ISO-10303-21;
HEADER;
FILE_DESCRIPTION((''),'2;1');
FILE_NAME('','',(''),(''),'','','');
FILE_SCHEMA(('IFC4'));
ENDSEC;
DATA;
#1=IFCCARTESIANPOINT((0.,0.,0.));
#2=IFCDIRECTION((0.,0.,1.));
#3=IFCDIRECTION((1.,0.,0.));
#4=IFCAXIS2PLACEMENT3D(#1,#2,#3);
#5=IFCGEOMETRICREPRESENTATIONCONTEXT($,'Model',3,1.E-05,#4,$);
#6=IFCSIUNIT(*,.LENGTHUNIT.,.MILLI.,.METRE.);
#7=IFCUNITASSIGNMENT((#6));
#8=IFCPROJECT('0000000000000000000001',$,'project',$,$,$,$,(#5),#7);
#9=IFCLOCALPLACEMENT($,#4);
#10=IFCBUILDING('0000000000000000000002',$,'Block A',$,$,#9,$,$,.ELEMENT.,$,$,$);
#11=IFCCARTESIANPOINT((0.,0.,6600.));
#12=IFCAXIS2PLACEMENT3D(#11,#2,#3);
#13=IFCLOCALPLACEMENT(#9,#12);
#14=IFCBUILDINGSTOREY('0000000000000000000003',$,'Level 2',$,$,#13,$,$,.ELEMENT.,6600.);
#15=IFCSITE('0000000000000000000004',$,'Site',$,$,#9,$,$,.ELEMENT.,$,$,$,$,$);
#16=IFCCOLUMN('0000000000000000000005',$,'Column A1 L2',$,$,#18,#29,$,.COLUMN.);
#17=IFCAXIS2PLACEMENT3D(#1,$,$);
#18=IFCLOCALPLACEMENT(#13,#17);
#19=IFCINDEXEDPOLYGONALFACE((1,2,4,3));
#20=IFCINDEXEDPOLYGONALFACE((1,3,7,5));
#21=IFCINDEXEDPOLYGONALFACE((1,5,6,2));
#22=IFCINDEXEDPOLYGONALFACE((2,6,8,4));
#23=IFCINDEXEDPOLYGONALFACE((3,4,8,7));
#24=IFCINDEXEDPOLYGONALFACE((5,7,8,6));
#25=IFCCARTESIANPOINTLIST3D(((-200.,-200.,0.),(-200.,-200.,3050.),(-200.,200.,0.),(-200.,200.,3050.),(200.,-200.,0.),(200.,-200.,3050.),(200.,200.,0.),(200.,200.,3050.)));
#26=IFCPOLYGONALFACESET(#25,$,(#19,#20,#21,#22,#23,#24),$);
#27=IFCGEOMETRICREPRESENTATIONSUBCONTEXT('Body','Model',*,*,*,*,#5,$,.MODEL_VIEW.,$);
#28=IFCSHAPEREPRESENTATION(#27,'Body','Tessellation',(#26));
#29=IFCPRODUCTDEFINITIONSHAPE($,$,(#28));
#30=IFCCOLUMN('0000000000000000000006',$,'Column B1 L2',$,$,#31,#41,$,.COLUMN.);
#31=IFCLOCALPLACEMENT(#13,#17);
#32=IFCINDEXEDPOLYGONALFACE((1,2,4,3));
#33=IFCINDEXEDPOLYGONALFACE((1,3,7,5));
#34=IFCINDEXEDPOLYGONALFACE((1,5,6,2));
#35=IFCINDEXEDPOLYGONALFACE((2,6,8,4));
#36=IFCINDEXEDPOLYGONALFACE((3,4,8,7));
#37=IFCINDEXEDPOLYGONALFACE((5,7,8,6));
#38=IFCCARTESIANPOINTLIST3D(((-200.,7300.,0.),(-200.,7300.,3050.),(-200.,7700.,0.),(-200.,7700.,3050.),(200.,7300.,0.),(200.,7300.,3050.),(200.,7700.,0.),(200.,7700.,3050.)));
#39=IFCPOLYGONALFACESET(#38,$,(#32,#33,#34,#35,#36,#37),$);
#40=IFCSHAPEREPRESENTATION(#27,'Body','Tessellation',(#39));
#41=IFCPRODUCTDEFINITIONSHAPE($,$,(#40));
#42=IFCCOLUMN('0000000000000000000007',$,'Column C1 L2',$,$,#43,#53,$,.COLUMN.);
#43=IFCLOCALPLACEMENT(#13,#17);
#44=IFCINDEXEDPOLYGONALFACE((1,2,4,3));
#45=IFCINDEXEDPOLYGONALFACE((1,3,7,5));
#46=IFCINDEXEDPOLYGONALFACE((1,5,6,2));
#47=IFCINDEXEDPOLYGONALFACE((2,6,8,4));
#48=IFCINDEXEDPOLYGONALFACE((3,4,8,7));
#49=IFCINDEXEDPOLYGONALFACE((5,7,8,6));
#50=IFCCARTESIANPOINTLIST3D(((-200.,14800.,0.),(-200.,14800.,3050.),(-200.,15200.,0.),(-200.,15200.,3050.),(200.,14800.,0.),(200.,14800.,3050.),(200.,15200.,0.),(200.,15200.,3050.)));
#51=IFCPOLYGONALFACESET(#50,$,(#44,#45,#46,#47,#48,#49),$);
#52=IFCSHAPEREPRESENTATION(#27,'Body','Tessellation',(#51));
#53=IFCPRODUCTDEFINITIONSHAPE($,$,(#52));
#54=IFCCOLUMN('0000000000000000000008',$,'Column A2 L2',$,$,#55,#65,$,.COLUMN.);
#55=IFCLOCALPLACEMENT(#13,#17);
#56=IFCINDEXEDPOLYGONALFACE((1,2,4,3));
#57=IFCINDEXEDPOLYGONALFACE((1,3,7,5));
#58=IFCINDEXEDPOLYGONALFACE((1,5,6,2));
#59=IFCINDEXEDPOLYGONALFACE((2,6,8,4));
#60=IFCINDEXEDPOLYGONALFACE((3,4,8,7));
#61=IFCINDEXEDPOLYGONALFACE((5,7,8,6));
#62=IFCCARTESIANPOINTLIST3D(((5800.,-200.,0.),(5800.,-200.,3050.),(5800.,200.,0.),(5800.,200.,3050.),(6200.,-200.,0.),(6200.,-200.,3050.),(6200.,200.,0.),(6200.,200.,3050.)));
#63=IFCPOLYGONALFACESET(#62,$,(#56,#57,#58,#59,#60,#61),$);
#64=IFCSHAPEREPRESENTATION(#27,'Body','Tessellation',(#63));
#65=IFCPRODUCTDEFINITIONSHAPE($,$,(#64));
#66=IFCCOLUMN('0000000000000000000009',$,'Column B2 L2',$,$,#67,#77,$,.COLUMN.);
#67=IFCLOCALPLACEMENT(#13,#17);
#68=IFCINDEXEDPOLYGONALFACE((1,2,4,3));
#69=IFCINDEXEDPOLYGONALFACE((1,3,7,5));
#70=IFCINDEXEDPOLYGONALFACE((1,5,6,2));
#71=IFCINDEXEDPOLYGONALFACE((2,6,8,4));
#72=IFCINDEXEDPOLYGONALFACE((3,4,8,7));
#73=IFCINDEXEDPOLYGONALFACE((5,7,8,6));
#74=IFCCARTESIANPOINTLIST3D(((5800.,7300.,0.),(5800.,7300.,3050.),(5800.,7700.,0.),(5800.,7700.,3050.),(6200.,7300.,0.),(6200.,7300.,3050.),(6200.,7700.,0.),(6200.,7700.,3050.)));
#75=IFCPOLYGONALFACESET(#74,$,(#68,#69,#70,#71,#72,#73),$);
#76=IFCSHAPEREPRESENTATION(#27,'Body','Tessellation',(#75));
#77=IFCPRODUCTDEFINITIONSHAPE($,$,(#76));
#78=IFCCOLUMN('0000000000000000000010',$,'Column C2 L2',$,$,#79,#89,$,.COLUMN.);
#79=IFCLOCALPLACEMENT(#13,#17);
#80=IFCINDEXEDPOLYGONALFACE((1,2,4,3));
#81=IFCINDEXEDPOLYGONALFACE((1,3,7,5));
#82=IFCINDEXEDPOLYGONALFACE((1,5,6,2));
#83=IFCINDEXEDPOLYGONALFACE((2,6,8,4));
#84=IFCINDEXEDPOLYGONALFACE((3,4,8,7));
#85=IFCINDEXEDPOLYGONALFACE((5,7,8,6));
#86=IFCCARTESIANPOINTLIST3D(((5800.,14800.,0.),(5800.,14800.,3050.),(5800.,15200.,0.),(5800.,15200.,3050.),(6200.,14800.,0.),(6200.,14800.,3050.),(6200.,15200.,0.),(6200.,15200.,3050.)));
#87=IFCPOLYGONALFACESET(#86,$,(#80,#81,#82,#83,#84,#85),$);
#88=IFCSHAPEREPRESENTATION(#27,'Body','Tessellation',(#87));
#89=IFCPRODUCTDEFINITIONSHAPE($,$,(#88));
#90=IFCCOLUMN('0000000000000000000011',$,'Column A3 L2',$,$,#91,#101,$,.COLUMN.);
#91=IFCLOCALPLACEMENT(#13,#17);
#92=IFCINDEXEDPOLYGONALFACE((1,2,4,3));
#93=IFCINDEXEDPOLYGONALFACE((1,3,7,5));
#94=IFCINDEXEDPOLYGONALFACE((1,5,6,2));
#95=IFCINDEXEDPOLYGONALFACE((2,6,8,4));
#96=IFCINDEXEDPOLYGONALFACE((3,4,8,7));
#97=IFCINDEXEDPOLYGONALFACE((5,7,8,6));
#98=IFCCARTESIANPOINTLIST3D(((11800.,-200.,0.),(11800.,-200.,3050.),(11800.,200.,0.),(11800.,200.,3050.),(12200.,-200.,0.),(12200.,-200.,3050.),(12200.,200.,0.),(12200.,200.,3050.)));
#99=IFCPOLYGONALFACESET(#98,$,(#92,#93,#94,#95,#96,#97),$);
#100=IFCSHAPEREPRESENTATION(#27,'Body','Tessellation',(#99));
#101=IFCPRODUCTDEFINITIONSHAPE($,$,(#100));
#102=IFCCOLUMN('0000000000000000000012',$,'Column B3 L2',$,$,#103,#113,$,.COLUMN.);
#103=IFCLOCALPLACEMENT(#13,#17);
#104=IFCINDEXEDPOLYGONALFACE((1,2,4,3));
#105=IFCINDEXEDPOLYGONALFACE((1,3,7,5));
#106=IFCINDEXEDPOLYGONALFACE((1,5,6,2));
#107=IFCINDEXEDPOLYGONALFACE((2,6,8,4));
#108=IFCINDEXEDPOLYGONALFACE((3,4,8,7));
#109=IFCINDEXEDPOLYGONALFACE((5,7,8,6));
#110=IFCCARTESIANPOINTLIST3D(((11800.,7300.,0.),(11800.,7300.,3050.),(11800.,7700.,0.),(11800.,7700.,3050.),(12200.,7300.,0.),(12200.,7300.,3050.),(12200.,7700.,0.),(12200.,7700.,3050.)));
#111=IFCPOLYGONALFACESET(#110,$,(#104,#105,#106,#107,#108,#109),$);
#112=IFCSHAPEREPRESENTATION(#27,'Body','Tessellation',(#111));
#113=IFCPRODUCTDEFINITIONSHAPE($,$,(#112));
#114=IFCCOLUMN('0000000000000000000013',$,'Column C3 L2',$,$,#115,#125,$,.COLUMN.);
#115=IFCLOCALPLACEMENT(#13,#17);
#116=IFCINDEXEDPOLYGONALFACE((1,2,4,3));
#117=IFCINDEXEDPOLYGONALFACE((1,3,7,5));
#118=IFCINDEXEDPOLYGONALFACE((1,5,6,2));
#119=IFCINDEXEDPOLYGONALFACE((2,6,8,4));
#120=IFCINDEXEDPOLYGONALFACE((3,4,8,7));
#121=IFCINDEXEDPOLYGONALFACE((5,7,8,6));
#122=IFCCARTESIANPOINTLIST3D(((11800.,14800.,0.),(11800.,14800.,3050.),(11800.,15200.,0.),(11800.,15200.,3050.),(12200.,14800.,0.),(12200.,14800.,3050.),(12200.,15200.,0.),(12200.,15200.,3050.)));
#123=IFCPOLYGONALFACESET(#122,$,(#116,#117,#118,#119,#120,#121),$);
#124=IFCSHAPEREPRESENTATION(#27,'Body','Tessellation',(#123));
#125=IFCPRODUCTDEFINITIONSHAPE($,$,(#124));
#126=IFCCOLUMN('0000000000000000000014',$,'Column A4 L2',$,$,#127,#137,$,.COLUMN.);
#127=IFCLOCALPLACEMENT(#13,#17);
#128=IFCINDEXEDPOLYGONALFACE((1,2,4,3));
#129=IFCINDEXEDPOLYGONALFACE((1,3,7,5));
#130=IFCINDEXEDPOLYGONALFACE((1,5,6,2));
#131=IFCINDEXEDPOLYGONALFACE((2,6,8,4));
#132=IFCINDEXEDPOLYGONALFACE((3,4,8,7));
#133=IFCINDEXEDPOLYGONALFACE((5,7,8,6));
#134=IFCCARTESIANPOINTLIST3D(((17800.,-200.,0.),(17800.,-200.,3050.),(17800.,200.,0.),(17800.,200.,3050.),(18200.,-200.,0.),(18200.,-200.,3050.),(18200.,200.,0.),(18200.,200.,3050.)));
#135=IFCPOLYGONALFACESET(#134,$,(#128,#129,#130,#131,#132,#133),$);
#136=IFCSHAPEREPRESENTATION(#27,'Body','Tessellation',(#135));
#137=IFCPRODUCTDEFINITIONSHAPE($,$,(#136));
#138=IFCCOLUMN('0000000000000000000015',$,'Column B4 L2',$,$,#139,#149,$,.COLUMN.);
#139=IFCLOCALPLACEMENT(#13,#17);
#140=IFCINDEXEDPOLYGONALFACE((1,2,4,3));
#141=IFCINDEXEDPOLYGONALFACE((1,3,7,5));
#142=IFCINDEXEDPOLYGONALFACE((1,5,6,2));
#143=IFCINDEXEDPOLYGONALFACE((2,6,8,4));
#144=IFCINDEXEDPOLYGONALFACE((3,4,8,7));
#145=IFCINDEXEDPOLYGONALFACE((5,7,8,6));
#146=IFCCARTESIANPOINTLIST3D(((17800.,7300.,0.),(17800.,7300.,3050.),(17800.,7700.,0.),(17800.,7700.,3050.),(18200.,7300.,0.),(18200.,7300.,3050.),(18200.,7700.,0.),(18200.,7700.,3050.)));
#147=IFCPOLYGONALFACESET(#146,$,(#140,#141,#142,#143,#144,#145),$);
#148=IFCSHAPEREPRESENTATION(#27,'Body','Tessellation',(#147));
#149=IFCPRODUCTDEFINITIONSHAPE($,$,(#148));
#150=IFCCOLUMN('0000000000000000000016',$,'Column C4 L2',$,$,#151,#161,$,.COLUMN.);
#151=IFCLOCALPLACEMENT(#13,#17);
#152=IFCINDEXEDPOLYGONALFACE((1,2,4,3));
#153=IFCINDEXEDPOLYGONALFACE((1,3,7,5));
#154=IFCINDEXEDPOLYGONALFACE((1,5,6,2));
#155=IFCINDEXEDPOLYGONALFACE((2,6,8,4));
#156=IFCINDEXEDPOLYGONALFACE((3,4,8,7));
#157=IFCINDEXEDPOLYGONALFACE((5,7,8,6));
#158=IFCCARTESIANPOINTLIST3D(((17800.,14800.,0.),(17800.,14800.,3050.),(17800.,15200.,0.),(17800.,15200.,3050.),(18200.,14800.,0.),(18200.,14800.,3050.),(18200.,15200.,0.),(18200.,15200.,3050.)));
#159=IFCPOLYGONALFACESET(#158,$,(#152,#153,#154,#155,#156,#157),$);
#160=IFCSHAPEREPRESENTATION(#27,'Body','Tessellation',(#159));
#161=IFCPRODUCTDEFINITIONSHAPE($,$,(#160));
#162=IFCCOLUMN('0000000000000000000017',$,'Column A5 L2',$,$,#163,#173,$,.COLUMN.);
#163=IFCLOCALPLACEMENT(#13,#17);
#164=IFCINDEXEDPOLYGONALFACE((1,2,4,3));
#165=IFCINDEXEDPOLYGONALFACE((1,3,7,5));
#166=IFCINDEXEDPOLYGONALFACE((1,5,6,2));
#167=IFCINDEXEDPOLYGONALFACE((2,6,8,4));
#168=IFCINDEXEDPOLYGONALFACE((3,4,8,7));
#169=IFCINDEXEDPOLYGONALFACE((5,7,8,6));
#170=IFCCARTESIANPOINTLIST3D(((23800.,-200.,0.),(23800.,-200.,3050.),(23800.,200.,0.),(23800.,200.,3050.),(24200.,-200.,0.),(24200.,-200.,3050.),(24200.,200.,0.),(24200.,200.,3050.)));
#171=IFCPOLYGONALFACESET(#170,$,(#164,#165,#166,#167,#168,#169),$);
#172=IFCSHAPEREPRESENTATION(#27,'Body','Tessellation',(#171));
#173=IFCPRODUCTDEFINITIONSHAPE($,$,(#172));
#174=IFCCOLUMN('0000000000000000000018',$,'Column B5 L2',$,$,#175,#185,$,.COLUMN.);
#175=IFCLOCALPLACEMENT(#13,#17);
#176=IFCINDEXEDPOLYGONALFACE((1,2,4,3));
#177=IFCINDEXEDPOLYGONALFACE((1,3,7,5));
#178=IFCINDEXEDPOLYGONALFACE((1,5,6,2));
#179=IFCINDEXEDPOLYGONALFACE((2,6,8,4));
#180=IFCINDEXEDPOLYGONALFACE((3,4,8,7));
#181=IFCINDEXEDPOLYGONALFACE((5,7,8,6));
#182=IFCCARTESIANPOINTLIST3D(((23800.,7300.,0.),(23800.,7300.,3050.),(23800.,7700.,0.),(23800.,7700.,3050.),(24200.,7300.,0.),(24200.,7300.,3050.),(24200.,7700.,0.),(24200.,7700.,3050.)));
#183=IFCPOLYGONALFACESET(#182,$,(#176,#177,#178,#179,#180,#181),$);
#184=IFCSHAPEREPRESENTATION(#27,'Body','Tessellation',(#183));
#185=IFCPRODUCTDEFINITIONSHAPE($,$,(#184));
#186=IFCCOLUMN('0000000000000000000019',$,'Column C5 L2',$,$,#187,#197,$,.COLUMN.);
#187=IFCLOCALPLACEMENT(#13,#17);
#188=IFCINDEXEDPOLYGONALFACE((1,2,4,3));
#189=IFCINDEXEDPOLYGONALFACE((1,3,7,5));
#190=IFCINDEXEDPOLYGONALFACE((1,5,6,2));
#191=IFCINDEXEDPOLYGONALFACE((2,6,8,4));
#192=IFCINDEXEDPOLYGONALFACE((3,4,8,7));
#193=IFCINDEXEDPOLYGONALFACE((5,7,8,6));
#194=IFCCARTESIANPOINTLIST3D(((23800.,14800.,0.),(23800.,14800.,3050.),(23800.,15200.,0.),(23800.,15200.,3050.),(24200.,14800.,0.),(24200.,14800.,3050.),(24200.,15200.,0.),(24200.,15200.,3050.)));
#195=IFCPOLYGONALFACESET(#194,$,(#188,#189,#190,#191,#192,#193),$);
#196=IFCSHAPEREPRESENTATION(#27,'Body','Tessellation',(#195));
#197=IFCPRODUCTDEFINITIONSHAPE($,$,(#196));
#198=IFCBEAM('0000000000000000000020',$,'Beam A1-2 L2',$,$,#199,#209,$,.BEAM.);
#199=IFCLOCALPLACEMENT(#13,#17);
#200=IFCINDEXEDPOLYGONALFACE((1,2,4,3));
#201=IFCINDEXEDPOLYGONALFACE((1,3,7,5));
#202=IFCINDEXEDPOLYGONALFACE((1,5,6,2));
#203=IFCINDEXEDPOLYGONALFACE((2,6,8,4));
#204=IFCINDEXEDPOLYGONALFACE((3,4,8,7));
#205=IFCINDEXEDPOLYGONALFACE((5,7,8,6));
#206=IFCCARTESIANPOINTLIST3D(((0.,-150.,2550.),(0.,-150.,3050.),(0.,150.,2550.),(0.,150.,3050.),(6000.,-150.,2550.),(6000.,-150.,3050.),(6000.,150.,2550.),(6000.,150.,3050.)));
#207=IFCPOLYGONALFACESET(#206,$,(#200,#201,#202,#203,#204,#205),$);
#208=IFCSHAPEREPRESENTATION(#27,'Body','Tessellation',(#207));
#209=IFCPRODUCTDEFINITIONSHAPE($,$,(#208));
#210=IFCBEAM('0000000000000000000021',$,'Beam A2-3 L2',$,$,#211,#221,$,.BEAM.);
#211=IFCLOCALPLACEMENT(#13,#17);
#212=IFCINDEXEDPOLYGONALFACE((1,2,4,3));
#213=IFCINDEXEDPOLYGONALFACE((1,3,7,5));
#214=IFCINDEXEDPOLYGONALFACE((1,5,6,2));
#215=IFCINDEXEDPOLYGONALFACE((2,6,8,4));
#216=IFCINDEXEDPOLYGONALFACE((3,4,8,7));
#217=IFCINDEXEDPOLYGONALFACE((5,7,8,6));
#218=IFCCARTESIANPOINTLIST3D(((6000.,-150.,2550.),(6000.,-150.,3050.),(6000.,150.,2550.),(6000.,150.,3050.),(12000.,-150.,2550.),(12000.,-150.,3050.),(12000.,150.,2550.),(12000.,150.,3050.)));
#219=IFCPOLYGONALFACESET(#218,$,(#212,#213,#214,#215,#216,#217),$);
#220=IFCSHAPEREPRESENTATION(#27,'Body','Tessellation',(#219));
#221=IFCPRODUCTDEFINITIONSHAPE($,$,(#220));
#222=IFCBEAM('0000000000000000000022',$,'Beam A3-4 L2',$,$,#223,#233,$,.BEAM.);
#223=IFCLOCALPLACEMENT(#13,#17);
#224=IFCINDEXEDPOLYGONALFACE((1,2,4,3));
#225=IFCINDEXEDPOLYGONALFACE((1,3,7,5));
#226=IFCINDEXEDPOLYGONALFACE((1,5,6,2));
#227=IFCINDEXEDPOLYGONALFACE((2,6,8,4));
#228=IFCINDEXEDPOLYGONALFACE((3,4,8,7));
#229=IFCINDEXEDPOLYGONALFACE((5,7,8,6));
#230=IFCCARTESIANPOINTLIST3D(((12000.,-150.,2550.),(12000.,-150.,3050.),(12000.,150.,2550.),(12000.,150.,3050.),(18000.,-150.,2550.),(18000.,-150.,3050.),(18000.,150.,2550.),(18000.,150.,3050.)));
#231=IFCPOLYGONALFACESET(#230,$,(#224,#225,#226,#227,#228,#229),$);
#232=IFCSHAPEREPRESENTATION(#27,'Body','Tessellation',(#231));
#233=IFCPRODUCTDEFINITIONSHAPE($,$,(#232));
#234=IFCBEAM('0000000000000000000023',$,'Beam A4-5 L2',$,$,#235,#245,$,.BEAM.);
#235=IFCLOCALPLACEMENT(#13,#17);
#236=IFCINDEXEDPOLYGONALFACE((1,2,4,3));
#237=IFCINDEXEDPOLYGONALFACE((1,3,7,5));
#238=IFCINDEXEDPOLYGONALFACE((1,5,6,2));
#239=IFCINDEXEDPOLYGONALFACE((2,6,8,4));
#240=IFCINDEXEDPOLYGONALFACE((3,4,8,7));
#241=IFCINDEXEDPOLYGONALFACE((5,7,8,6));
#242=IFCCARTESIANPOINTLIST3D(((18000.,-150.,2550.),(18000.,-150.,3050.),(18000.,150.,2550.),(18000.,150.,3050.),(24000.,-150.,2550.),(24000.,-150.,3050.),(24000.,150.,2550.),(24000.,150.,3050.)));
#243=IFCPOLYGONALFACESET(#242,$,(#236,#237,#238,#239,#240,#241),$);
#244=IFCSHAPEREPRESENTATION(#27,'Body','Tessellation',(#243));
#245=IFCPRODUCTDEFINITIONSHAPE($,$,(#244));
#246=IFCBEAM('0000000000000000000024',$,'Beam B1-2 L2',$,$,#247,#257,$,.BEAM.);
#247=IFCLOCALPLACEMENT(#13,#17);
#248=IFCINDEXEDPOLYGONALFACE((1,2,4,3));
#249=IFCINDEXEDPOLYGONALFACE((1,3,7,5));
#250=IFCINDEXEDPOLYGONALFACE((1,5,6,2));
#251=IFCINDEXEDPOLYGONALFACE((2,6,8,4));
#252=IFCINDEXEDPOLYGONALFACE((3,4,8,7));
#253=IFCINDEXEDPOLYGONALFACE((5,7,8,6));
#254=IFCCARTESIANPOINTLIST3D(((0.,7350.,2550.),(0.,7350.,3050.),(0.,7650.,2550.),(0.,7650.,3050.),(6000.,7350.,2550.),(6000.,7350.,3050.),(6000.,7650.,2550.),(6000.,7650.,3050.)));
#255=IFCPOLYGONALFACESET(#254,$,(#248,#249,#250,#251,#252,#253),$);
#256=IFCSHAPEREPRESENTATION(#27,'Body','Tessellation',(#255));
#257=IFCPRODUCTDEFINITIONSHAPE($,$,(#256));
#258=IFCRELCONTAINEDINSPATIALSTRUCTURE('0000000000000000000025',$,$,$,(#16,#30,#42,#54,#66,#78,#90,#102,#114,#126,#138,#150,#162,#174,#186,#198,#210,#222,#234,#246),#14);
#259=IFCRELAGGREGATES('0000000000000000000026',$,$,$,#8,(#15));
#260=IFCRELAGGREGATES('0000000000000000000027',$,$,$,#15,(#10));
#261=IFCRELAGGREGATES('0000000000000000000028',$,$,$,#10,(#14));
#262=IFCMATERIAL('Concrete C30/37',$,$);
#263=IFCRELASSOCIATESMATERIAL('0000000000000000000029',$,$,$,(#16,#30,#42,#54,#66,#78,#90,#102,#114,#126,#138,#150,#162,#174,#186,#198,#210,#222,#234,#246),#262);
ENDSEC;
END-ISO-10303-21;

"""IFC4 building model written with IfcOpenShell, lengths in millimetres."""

from ifc_helpers import new_model, si_unit, frame, frame_2d, origin_with_axes, origin_2d, place, context, subcontext, project, spatial, rectangle, extrude, material, element, save


model = new_model("IFC4")

# Units and contexts
model_context = context("Model", 3, precision=1e-05, world=origin_with_axes())
body_context = subcontext(model_context, "Body", "Model", "MODEL_VIEW")
ifc_project = project(units=[si_unit("LENGTHUNIT", "METRE", prefix="MILLI")], contexts=[model_context])

# Site, building, storey
placement = place(None, origin_with_axes())
site = spatial("IfcSite", under=ifc_project, at=placement, Name="Site", CompositionType="ELEMENT")
building = spatial("IfcBuilding", under=site, at=placement, Name="Block A", CompositionType="ELEMENT")
storey_placement = place(placement, frame((0.0, 0.0, 6600.0), z_axis=(0.0, 0.0, 1.0), x_axis=(1.0, 0.0, 0.0)))
storey = spatial("IfcBuildingStorey", under=building, at=storey_placement, Name="Level 2", CompositionType="ELEMENT", Elevation=6600.0)

# Columns
ifc_material_1 = material(Name="Concrete C30/37")
for number, where, z_axis, x_axis, name in (
    (1, (0.0, 0.0, 6600.0), (0.0, 0.0, 1.0), (1.0, 0.0, 0.0), "Column A1 L2"),
    (2, (0.0, 7500.0, 6600.0), (0.0, 0.0, 1.0), (1.0, 0.0, 0.0), "Column B1 L2"),
    (3, (0.0, 15000.0, 6600.0), (0.0, 0.0, 1.0), (1.0, 0.0, 0.0), "Column C1 L2"),
    (4, (6000.0, 0.0, 6600.0), (0.0, 0.0, 1.0), (1.0, 0.0, 0.0), "Column A2 L2"),
    (5, (6000.0, 7500.0, 6600.0), (0.0, 0.0, 1.0), (1.0, 0.0, 0.0), "Column B2 L2"),
    (6, (6000.0, 15000.0, 6600.0), (0.0, 0.0, 1.0), (1.0, 0.0, 0.0), "Column C2 L2"),
    (7, (12000.0, 0.0, 6600.0), (0.0, 0.0, 1.0), (1.0, 0.0, 0.0), "Column A3 L2"),
    (8, (12000.0, 7500.0, 6600.0), (0.0, 0.0, 1.0), (1.0, 0.0, 0.0), "Column B3 L2"),
    (9, (12000.0, 15000.0, 6600.0), (0.0, 0.0, 1.0), (1.0, 0.0, 0.0), "Column C3 L2"),
    (10, (18000.0, 0.0, 6600.0), (0.0, 0.0, 1.0), (1.0, 0.0, 0.0), "Column A4 L2"),
    (11, (18000.0, 7500.0, 6600.0), (0.0, 0.0, 1.0), (1.0, 0.0, 0.0), "Column B4 L2"),
    (12, (18000.0, 15000.0, 6600.0), (0.0, 0.0, 1.0), (1.0, 0.0, 0.0), "Column C4 L2"),
    (13, (24000.0, 0.0, 6600.0), (0.0, 0.0, 1.0), (1.0, 0.0, 0.0), "Column A5 L2"),
    (14, (24000.0, 7500.0, 6600.0), (0.0, 0.0, 1.0), (1.0, 0.0, 0.0), "Column B5 L2"),
    (15, (24000.0, 15000.0, 6600.0), (0.0, 0.0, 1.0), (1.0, 0.0, 0.0), "Column C5 L2"),
):
    element("IfcColumn", number, at=place(placement, frame(where, z_axis=z_axis, x_axis=x_axis)), inside=storey, material=ifc_material_1, Name=name, PredefinedType="COLUMN", context=body_context, shape_type="SweptSolid", body=[
        extrude(rectangle(XDim=400.0, YDim=400.0, at=origin_2d()), origin_with_axes(), (0.0, 0.0, 1.0), 3050.0),
    ])

# Beams
for number, where, z_axis, x_axis, name in (
    (16, (0.0, 0.0, 9150.0), (0.0, 0.0, 1.0), (1.0, 0.0, 0.0), "Beam A1-2 L2"),
    (17, (6000.0, 0.0, 9150.0), (0.0, 0.0, 1.0), (1.0, 0.0, 0.0), "Beam A2-3 L2"),
    (18, (12000.0, 0.0, 9150.0), (0.0, 0.0, 1.0), (1.0, 0.0, 0.0), "Beam A3-4 L2"),
    (19, (18000.0, 0.0, 9150.0), (0.0, 0.0, 1.0), (1.0, 0.0, 0.0), "Beam A4-5 L2"),
    (20, (0.0, 7500.0, 9150.0), (0.0, 0.0, 1.0), (1.0, 0.0, 0.0), "Beam B1-2 L2"),
):
    element("IfcBeam", number, at=place(placement, frame(where, z_axis=z_axis, x_axis=x_axis)), inside=storey, material=ifc_material_1, Name=name, PredefinedType="BEAM", context=body_context, shape_type="SweptSolid", body=[
        extrude(rectangle(XDim=6000.0, YDim=300.0, at=frame_2d((3000.0, 0.0))), origin_with_axes(), (0.0, 0.0, 1.0), 500.0),
    ])

save(model, "model.ifc")
